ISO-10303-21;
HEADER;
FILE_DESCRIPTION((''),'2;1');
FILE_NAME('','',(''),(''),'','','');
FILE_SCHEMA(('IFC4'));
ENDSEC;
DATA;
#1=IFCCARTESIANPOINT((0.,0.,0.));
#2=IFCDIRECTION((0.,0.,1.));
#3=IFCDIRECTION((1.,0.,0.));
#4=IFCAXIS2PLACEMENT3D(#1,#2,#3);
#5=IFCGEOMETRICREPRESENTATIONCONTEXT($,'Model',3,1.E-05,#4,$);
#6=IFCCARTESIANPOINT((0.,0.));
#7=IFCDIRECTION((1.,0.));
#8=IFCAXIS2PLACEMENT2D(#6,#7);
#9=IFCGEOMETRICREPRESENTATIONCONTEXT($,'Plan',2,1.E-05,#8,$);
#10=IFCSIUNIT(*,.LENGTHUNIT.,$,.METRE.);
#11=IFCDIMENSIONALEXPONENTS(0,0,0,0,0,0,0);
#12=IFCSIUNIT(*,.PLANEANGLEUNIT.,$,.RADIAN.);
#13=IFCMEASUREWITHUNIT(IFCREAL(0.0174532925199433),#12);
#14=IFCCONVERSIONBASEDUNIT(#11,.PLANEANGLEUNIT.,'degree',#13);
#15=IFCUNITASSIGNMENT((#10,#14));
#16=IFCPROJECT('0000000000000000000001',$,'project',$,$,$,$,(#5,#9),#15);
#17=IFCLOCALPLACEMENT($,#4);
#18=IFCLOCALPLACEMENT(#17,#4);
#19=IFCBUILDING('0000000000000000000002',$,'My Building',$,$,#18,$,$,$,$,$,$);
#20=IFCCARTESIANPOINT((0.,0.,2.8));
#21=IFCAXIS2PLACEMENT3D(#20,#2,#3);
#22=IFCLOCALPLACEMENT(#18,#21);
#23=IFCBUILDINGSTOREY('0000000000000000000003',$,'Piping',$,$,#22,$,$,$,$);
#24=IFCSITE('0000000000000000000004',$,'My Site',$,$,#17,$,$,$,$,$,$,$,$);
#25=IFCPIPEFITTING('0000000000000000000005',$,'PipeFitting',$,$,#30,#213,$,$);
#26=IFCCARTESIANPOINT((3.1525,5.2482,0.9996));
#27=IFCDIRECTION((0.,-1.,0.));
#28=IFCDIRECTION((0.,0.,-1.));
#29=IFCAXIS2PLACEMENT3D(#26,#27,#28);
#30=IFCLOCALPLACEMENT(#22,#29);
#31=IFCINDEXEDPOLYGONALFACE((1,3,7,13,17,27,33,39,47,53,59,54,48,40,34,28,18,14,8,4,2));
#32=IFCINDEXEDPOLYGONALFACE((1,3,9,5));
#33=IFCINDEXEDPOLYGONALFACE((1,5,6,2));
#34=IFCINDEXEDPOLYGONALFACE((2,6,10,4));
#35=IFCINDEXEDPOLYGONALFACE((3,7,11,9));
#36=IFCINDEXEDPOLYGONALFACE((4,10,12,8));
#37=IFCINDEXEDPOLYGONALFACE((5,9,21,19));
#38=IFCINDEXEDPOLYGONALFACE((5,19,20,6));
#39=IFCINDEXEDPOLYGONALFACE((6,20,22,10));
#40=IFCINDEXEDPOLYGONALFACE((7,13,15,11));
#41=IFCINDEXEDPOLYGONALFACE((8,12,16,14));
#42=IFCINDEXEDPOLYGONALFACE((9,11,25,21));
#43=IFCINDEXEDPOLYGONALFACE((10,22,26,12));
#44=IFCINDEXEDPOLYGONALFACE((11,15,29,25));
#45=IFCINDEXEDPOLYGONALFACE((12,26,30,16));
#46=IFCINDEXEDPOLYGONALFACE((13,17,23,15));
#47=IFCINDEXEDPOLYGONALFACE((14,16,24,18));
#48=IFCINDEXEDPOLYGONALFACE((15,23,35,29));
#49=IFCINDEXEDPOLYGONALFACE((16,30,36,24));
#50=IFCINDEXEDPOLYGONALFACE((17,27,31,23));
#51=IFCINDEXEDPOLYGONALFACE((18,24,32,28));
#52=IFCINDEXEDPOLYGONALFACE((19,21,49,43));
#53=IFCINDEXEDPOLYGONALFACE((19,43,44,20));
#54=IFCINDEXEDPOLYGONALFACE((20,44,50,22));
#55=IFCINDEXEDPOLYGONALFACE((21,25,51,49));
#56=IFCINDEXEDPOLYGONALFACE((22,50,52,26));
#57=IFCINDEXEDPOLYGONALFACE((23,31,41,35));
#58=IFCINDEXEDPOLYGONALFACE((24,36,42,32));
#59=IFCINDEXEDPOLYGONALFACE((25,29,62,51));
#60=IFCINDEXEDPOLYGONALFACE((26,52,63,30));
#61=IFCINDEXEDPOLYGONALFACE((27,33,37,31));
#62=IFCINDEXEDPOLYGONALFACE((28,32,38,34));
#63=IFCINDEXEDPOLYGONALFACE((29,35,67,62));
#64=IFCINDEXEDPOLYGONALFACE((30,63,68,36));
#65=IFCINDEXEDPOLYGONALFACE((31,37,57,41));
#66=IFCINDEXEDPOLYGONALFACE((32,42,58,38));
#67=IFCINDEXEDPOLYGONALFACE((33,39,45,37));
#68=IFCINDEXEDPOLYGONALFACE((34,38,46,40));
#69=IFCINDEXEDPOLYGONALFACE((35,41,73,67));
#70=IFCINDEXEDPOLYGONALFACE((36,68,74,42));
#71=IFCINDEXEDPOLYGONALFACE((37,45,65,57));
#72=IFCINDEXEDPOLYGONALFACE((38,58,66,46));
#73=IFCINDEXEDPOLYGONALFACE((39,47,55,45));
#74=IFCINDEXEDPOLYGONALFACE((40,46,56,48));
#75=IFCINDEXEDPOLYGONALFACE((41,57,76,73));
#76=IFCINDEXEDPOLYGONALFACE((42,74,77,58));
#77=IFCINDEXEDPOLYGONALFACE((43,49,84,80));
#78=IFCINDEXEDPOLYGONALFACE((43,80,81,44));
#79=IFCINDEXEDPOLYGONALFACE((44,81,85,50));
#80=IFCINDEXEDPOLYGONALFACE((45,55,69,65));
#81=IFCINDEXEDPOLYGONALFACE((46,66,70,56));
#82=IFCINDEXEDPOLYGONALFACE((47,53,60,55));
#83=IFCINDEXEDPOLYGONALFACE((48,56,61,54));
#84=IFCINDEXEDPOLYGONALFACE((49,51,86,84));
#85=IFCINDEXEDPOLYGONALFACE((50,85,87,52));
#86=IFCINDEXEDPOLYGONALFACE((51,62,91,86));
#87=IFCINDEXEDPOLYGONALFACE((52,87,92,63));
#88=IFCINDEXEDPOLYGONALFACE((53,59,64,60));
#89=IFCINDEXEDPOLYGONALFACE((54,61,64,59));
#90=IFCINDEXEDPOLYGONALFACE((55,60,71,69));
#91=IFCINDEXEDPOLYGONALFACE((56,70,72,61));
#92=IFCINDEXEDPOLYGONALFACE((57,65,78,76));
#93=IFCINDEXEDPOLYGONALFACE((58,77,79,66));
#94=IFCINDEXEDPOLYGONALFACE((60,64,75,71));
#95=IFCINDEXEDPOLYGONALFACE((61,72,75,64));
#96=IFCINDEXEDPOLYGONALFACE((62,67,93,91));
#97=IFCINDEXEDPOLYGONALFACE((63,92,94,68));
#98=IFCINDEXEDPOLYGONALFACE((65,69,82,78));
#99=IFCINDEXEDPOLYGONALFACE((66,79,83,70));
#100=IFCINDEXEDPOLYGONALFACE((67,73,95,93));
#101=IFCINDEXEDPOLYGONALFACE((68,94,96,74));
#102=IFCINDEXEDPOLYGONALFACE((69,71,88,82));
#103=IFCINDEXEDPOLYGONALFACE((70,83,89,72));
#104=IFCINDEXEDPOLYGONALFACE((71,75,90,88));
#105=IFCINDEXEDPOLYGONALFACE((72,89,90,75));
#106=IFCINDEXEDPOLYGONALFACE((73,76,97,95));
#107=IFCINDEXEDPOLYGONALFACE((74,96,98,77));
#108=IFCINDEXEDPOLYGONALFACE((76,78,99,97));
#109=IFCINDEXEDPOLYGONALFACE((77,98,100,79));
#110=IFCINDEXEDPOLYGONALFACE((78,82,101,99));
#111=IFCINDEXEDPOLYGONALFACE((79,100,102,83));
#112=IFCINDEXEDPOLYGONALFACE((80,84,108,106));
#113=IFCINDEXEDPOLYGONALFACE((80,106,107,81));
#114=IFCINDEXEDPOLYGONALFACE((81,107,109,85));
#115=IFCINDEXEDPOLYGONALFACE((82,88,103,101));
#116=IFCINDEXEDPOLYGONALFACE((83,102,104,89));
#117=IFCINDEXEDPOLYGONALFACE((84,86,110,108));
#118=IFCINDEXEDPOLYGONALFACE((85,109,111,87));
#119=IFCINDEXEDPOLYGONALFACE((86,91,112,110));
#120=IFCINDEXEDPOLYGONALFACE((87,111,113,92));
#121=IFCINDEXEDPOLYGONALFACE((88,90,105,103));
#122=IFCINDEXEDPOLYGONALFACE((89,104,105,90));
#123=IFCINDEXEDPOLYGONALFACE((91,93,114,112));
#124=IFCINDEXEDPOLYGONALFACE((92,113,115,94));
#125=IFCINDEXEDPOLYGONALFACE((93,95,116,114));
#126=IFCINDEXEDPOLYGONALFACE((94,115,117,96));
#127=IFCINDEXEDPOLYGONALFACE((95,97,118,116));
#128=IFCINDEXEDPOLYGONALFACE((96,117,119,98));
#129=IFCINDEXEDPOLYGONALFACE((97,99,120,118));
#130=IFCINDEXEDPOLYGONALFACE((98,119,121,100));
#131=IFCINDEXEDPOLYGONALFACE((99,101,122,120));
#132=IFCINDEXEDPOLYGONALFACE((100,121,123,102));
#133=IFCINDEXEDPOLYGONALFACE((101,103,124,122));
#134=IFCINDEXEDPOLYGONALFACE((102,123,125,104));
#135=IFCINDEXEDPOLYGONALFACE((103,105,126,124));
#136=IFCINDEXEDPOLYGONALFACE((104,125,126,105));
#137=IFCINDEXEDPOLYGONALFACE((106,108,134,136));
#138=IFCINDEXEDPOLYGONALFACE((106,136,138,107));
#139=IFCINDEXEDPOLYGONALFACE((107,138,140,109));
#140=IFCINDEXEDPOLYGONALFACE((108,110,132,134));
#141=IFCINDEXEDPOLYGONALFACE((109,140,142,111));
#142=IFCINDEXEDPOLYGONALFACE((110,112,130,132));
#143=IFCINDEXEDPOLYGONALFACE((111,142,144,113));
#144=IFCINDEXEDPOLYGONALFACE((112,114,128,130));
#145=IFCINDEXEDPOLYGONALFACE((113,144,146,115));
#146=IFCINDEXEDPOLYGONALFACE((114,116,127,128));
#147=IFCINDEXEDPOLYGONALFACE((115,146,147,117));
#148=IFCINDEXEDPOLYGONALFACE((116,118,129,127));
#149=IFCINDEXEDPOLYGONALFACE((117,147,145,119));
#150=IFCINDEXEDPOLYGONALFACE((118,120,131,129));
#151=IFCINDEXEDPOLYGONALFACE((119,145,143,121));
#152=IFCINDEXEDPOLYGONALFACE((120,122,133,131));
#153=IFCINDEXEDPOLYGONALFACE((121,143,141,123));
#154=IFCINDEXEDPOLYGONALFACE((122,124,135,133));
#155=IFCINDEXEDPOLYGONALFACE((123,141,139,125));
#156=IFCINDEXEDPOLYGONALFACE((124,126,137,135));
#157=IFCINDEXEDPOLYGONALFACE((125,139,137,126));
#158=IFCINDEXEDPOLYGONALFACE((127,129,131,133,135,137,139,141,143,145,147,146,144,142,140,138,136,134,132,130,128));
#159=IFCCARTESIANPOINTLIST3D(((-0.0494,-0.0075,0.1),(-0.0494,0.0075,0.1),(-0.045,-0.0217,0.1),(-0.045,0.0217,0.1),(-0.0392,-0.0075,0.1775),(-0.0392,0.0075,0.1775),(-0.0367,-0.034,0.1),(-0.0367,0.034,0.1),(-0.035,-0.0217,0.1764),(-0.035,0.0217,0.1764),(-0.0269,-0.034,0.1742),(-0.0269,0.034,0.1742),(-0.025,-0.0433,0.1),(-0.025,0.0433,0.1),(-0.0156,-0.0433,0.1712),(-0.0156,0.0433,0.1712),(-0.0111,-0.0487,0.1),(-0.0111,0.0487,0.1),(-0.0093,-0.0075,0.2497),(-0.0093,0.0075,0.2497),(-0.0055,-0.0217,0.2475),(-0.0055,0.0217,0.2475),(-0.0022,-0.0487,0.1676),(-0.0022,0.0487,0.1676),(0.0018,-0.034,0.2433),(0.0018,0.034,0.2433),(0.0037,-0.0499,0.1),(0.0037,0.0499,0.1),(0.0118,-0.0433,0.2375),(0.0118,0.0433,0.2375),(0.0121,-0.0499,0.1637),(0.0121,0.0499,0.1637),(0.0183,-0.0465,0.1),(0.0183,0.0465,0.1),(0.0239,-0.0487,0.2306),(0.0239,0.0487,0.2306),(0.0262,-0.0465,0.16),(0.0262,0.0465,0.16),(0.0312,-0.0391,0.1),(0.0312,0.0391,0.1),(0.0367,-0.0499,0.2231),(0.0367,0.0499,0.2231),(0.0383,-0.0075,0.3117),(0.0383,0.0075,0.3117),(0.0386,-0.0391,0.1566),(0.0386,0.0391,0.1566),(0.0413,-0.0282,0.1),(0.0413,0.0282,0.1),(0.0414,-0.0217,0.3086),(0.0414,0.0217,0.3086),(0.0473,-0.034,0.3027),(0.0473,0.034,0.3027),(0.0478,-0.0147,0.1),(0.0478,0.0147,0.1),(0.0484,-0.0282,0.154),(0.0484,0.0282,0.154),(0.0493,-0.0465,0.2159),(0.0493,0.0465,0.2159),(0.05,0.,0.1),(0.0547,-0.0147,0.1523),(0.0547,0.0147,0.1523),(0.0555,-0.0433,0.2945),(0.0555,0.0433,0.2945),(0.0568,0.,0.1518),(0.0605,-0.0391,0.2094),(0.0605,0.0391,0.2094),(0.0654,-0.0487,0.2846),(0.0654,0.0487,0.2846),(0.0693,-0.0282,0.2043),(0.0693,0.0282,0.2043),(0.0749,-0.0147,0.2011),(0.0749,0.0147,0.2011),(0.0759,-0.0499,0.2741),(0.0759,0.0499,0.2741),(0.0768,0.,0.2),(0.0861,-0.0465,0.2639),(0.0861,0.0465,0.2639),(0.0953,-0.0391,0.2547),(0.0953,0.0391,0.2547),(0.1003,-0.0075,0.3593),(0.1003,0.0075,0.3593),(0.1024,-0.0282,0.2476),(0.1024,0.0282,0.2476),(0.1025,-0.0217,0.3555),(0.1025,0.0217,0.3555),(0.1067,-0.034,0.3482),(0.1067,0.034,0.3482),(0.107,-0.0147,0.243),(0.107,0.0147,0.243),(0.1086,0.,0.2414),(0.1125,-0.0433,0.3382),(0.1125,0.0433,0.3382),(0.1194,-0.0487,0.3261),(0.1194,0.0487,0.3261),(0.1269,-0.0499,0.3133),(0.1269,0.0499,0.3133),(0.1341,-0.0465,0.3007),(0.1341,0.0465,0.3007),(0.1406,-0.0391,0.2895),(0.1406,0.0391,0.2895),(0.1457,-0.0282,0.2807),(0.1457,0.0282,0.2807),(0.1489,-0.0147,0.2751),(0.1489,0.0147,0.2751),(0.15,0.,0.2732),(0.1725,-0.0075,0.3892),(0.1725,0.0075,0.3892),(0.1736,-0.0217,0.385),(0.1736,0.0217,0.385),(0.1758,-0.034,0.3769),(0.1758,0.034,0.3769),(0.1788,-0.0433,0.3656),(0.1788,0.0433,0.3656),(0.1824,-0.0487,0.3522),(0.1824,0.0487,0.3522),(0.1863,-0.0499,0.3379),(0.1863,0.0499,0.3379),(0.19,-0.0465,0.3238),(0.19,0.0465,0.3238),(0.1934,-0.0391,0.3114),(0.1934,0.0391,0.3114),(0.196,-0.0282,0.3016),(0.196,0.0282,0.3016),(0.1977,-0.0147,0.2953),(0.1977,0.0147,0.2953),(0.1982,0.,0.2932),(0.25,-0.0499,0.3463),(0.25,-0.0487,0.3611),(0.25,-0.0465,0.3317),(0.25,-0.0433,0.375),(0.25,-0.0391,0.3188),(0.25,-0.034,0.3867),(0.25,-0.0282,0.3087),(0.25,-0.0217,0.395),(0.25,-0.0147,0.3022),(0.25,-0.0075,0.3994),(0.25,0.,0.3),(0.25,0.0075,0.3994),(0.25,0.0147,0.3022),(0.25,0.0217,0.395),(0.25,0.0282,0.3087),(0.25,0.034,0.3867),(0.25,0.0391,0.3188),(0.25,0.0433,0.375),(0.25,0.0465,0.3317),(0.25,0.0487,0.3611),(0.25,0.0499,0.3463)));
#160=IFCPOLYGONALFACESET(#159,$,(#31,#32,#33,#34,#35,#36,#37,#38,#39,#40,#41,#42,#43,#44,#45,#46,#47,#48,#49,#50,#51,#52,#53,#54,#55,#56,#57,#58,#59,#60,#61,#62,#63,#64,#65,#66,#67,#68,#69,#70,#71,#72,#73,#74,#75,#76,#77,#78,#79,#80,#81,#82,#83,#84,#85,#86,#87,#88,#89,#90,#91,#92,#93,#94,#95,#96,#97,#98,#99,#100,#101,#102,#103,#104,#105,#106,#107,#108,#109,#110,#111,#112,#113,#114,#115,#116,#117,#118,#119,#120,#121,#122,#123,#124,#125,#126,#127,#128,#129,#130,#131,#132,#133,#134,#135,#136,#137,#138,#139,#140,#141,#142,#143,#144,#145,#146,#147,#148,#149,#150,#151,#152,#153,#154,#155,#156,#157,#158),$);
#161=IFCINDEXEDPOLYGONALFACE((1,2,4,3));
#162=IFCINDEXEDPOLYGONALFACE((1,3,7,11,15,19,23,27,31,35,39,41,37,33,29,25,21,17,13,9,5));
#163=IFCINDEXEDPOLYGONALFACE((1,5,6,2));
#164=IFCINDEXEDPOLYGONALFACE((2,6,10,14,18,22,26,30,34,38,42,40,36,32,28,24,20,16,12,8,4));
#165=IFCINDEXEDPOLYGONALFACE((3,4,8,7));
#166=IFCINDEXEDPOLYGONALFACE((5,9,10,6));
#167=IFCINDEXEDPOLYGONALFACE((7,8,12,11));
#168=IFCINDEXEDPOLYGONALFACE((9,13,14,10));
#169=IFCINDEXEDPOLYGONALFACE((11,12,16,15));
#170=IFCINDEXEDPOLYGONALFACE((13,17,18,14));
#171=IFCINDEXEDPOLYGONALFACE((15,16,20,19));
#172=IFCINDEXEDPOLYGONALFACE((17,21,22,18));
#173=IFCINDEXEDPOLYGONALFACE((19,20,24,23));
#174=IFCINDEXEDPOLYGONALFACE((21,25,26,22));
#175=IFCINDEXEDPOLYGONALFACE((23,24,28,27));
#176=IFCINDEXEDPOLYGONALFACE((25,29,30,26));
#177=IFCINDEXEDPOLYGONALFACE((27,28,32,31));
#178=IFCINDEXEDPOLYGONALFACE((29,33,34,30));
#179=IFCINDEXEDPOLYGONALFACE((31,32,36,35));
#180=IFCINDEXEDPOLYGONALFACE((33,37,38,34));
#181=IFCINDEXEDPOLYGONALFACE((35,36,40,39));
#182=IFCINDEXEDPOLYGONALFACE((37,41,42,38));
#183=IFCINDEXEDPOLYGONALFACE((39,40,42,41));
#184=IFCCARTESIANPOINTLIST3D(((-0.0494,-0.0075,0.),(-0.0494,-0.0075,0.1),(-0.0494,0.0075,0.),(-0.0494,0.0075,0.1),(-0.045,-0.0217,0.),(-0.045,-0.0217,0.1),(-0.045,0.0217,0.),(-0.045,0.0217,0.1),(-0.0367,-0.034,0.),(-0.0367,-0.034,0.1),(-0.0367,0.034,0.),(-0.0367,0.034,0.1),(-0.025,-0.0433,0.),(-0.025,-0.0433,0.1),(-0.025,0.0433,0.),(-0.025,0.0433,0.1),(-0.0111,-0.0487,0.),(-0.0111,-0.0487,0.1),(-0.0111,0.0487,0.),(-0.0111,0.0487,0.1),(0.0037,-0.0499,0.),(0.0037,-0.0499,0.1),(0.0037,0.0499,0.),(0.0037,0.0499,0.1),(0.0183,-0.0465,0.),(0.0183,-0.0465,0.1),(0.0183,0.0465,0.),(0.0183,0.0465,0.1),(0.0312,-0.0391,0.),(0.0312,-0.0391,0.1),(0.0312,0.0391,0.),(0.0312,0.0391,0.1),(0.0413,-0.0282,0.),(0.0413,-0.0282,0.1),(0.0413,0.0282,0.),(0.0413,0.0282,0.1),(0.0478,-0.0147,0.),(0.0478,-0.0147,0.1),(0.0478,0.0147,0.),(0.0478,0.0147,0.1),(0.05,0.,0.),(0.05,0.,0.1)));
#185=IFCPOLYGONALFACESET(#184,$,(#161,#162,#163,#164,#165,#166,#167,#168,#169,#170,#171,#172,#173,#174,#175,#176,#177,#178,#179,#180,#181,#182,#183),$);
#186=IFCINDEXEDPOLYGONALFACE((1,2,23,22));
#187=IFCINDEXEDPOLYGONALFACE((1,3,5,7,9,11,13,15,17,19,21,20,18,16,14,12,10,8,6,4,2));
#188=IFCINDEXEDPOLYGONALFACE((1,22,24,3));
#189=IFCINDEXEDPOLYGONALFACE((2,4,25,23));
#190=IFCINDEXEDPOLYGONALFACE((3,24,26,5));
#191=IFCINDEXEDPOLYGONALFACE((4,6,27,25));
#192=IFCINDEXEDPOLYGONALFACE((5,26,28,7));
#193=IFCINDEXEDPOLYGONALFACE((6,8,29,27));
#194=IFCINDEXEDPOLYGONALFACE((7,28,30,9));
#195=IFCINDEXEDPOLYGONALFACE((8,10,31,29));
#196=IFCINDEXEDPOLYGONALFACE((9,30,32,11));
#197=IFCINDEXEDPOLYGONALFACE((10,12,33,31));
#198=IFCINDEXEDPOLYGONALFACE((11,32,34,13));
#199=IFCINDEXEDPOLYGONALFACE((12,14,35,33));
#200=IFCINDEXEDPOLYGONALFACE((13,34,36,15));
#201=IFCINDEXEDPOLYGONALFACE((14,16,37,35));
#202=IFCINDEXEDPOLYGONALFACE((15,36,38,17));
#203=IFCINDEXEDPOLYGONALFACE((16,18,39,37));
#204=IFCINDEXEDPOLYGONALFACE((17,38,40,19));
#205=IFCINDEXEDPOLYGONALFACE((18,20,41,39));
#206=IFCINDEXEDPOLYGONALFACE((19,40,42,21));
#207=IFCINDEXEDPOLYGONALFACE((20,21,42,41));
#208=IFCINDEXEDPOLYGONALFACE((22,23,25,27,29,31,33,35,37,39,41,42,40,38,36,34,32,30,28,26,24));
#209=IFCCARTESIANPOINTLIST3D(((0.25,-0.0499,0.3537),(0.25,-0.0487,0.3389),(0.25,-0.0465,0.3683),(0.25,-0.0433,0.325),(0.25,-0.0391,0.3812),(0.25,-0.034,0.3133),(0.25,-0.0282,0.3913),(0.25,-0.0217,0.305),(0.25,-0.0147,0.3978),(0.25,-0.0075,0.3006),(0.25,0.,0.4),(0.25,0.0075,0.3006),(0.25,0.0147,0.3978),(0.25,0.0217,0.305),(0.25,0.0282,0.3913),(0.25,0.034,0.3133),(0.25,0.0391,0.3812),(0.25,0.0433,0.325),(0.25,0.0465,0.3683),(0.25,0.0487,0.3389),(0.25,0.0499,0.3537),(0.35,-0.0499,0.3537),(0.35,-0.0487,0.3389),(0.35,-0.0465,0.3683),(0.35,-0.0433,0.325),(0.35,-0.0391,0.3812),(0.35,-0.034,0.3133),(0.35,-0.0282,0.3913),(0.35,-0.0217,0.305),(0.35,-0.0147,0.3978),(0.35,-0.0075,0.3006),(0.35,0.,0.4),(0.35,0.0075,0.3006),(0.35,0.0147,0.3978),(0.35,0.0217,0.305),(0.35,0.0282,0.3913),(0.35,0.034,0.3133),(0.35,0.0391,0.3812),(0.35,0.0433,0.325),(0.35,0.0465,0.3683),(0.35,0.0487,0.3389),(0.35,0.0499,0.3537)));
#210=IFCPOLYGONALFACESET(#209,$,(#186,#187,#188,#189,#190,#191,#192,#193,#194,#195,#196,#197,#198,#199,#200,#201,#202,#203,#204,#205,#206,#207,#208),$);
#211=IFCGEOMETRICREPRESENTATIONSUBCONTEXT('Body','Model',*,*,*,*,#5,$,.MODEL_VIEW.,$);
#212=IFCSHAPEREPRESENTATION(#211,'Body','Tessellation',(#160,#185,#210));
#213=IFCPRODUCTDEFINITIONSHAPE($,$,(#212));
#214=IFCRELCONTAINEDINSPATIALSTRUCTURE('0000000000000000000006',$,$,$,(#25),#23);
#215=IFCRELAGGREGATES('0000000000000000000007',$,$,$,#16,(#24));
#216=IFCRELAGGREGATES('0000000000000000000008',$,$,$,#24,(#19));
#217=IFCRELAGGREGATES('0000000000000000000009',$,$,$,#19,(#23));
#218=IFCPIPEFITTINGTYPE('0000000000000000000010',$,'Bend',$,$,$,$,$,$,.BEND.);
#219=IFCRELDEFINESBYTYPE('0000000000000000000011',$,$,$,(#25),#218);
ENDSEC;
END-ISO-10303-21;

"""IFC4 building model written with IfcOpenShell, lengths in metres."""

from ifc_helpers import new_model, entity, si_unit, converted_unit, frame, origin_with_axes, origin_2d_with_axis, place, context, subcontext, project, spatial, circle, extrude, source, transform, mapped, type_object, type_shapes, element, save


model = new_model("IFC4")

# Units and contexts
model_context = context("Model", 3, precision=1e-05, world=origin_with_axes())
plan_context = context("Plan", 2, precision=1e-05, world=origin_2d_with_axis())
body_context = subcontext(model_context, "Body", "Model", "MODEL_VIEW")
ifc_project = project(units=[si_unit("LENGTHUNIT", "METRE"), converted_unit("PLANEANGLEUNIT", "degree", entity("IfcReal", 0.0174532925199433), si_unit("PLANEANGLEUNIT", "RADIAN"), dimensions=[0, 0, 0, 0, 0, 0, 0])], contexts=[model_context, plan_context])

# Site, building, storey
site_placement = place(None, origin_with_axes())
site = spatial("IfcSite", under=ifc_project, at=site_placement, Name="My Site")
building_placement = place(site_placement, origin_with_axes())
building = spatial("IfcBuilding", under=site, at=building_placement, Name="My Building")
storey_placement = place(building_placement, frame((0.0, 0.0, 2.8), z_axis=(0.0, 0.0, 1.0), x_axis=(1.0, 0.0, 0.0)))
storey = spatial("IfcBuildingStorey", under=building, at=storey_placement, Name="Piping")

# Pipe fitting
pipe_fitting_type_1 = type_object("IfcPipeFittingType", Name="Bend", PredefinedType="BEND")
shared_shape = source(origin_with_axes(), body_context, "Body", "SolidModel", [
    entity("IfcSweptDiskSolid", entity("IfcIndexedPolyCurve", entity("IfcCartesianPointList3D", [[0.0, 0.0, 0.1], [0.0732, 0.0, 0.2768], [0.25, 0.0, 0.35]]), [entity("IfcArcIndex", [1, 2, 3])]), 0.05),
    extrude(circle(Radius=0.05), origin_with_axes(), (0.0, 0.0, 1.0), 0.1),
    extrude(circle(Radius=0.05), frame((0.25, 0.0, 0.35), z_axis=(1.0, 0.0, 0.0), x_axis=(0.0, 0.0, 1.0)), (0.0, 0.0, 1.0), 0.1),
])
type_shapes(pipe_fitting_type_1, [shared_shape])
for number, where, z_axis, x_axis, name in (
    (1, (3.1525, 5.2482, 0.9996), (0.0, -1.0, 0.0), (0.0, 0.0, -1.0), "PipeFitting"),
):
    element("IfcPipeFitting", number, at=place(storey_placement, frame(where, z_axis=z_axis, x_axis=x_axis)), inside=storey, type_object=pipe_fitting_type_1, Name=name, context=body_context, shape_type="MappedRepresentation", body=[
        mapped(shared_shape, transform((0.0, 0.0, 0.0), x_axis=(1.0, 0.0, 0.0), y_axis=(0.0, 1.0, 0.0), z_axis=(0.0, 0.0, 1.0), scale=1.0)),
    ])

save(model, "model.ifc")
